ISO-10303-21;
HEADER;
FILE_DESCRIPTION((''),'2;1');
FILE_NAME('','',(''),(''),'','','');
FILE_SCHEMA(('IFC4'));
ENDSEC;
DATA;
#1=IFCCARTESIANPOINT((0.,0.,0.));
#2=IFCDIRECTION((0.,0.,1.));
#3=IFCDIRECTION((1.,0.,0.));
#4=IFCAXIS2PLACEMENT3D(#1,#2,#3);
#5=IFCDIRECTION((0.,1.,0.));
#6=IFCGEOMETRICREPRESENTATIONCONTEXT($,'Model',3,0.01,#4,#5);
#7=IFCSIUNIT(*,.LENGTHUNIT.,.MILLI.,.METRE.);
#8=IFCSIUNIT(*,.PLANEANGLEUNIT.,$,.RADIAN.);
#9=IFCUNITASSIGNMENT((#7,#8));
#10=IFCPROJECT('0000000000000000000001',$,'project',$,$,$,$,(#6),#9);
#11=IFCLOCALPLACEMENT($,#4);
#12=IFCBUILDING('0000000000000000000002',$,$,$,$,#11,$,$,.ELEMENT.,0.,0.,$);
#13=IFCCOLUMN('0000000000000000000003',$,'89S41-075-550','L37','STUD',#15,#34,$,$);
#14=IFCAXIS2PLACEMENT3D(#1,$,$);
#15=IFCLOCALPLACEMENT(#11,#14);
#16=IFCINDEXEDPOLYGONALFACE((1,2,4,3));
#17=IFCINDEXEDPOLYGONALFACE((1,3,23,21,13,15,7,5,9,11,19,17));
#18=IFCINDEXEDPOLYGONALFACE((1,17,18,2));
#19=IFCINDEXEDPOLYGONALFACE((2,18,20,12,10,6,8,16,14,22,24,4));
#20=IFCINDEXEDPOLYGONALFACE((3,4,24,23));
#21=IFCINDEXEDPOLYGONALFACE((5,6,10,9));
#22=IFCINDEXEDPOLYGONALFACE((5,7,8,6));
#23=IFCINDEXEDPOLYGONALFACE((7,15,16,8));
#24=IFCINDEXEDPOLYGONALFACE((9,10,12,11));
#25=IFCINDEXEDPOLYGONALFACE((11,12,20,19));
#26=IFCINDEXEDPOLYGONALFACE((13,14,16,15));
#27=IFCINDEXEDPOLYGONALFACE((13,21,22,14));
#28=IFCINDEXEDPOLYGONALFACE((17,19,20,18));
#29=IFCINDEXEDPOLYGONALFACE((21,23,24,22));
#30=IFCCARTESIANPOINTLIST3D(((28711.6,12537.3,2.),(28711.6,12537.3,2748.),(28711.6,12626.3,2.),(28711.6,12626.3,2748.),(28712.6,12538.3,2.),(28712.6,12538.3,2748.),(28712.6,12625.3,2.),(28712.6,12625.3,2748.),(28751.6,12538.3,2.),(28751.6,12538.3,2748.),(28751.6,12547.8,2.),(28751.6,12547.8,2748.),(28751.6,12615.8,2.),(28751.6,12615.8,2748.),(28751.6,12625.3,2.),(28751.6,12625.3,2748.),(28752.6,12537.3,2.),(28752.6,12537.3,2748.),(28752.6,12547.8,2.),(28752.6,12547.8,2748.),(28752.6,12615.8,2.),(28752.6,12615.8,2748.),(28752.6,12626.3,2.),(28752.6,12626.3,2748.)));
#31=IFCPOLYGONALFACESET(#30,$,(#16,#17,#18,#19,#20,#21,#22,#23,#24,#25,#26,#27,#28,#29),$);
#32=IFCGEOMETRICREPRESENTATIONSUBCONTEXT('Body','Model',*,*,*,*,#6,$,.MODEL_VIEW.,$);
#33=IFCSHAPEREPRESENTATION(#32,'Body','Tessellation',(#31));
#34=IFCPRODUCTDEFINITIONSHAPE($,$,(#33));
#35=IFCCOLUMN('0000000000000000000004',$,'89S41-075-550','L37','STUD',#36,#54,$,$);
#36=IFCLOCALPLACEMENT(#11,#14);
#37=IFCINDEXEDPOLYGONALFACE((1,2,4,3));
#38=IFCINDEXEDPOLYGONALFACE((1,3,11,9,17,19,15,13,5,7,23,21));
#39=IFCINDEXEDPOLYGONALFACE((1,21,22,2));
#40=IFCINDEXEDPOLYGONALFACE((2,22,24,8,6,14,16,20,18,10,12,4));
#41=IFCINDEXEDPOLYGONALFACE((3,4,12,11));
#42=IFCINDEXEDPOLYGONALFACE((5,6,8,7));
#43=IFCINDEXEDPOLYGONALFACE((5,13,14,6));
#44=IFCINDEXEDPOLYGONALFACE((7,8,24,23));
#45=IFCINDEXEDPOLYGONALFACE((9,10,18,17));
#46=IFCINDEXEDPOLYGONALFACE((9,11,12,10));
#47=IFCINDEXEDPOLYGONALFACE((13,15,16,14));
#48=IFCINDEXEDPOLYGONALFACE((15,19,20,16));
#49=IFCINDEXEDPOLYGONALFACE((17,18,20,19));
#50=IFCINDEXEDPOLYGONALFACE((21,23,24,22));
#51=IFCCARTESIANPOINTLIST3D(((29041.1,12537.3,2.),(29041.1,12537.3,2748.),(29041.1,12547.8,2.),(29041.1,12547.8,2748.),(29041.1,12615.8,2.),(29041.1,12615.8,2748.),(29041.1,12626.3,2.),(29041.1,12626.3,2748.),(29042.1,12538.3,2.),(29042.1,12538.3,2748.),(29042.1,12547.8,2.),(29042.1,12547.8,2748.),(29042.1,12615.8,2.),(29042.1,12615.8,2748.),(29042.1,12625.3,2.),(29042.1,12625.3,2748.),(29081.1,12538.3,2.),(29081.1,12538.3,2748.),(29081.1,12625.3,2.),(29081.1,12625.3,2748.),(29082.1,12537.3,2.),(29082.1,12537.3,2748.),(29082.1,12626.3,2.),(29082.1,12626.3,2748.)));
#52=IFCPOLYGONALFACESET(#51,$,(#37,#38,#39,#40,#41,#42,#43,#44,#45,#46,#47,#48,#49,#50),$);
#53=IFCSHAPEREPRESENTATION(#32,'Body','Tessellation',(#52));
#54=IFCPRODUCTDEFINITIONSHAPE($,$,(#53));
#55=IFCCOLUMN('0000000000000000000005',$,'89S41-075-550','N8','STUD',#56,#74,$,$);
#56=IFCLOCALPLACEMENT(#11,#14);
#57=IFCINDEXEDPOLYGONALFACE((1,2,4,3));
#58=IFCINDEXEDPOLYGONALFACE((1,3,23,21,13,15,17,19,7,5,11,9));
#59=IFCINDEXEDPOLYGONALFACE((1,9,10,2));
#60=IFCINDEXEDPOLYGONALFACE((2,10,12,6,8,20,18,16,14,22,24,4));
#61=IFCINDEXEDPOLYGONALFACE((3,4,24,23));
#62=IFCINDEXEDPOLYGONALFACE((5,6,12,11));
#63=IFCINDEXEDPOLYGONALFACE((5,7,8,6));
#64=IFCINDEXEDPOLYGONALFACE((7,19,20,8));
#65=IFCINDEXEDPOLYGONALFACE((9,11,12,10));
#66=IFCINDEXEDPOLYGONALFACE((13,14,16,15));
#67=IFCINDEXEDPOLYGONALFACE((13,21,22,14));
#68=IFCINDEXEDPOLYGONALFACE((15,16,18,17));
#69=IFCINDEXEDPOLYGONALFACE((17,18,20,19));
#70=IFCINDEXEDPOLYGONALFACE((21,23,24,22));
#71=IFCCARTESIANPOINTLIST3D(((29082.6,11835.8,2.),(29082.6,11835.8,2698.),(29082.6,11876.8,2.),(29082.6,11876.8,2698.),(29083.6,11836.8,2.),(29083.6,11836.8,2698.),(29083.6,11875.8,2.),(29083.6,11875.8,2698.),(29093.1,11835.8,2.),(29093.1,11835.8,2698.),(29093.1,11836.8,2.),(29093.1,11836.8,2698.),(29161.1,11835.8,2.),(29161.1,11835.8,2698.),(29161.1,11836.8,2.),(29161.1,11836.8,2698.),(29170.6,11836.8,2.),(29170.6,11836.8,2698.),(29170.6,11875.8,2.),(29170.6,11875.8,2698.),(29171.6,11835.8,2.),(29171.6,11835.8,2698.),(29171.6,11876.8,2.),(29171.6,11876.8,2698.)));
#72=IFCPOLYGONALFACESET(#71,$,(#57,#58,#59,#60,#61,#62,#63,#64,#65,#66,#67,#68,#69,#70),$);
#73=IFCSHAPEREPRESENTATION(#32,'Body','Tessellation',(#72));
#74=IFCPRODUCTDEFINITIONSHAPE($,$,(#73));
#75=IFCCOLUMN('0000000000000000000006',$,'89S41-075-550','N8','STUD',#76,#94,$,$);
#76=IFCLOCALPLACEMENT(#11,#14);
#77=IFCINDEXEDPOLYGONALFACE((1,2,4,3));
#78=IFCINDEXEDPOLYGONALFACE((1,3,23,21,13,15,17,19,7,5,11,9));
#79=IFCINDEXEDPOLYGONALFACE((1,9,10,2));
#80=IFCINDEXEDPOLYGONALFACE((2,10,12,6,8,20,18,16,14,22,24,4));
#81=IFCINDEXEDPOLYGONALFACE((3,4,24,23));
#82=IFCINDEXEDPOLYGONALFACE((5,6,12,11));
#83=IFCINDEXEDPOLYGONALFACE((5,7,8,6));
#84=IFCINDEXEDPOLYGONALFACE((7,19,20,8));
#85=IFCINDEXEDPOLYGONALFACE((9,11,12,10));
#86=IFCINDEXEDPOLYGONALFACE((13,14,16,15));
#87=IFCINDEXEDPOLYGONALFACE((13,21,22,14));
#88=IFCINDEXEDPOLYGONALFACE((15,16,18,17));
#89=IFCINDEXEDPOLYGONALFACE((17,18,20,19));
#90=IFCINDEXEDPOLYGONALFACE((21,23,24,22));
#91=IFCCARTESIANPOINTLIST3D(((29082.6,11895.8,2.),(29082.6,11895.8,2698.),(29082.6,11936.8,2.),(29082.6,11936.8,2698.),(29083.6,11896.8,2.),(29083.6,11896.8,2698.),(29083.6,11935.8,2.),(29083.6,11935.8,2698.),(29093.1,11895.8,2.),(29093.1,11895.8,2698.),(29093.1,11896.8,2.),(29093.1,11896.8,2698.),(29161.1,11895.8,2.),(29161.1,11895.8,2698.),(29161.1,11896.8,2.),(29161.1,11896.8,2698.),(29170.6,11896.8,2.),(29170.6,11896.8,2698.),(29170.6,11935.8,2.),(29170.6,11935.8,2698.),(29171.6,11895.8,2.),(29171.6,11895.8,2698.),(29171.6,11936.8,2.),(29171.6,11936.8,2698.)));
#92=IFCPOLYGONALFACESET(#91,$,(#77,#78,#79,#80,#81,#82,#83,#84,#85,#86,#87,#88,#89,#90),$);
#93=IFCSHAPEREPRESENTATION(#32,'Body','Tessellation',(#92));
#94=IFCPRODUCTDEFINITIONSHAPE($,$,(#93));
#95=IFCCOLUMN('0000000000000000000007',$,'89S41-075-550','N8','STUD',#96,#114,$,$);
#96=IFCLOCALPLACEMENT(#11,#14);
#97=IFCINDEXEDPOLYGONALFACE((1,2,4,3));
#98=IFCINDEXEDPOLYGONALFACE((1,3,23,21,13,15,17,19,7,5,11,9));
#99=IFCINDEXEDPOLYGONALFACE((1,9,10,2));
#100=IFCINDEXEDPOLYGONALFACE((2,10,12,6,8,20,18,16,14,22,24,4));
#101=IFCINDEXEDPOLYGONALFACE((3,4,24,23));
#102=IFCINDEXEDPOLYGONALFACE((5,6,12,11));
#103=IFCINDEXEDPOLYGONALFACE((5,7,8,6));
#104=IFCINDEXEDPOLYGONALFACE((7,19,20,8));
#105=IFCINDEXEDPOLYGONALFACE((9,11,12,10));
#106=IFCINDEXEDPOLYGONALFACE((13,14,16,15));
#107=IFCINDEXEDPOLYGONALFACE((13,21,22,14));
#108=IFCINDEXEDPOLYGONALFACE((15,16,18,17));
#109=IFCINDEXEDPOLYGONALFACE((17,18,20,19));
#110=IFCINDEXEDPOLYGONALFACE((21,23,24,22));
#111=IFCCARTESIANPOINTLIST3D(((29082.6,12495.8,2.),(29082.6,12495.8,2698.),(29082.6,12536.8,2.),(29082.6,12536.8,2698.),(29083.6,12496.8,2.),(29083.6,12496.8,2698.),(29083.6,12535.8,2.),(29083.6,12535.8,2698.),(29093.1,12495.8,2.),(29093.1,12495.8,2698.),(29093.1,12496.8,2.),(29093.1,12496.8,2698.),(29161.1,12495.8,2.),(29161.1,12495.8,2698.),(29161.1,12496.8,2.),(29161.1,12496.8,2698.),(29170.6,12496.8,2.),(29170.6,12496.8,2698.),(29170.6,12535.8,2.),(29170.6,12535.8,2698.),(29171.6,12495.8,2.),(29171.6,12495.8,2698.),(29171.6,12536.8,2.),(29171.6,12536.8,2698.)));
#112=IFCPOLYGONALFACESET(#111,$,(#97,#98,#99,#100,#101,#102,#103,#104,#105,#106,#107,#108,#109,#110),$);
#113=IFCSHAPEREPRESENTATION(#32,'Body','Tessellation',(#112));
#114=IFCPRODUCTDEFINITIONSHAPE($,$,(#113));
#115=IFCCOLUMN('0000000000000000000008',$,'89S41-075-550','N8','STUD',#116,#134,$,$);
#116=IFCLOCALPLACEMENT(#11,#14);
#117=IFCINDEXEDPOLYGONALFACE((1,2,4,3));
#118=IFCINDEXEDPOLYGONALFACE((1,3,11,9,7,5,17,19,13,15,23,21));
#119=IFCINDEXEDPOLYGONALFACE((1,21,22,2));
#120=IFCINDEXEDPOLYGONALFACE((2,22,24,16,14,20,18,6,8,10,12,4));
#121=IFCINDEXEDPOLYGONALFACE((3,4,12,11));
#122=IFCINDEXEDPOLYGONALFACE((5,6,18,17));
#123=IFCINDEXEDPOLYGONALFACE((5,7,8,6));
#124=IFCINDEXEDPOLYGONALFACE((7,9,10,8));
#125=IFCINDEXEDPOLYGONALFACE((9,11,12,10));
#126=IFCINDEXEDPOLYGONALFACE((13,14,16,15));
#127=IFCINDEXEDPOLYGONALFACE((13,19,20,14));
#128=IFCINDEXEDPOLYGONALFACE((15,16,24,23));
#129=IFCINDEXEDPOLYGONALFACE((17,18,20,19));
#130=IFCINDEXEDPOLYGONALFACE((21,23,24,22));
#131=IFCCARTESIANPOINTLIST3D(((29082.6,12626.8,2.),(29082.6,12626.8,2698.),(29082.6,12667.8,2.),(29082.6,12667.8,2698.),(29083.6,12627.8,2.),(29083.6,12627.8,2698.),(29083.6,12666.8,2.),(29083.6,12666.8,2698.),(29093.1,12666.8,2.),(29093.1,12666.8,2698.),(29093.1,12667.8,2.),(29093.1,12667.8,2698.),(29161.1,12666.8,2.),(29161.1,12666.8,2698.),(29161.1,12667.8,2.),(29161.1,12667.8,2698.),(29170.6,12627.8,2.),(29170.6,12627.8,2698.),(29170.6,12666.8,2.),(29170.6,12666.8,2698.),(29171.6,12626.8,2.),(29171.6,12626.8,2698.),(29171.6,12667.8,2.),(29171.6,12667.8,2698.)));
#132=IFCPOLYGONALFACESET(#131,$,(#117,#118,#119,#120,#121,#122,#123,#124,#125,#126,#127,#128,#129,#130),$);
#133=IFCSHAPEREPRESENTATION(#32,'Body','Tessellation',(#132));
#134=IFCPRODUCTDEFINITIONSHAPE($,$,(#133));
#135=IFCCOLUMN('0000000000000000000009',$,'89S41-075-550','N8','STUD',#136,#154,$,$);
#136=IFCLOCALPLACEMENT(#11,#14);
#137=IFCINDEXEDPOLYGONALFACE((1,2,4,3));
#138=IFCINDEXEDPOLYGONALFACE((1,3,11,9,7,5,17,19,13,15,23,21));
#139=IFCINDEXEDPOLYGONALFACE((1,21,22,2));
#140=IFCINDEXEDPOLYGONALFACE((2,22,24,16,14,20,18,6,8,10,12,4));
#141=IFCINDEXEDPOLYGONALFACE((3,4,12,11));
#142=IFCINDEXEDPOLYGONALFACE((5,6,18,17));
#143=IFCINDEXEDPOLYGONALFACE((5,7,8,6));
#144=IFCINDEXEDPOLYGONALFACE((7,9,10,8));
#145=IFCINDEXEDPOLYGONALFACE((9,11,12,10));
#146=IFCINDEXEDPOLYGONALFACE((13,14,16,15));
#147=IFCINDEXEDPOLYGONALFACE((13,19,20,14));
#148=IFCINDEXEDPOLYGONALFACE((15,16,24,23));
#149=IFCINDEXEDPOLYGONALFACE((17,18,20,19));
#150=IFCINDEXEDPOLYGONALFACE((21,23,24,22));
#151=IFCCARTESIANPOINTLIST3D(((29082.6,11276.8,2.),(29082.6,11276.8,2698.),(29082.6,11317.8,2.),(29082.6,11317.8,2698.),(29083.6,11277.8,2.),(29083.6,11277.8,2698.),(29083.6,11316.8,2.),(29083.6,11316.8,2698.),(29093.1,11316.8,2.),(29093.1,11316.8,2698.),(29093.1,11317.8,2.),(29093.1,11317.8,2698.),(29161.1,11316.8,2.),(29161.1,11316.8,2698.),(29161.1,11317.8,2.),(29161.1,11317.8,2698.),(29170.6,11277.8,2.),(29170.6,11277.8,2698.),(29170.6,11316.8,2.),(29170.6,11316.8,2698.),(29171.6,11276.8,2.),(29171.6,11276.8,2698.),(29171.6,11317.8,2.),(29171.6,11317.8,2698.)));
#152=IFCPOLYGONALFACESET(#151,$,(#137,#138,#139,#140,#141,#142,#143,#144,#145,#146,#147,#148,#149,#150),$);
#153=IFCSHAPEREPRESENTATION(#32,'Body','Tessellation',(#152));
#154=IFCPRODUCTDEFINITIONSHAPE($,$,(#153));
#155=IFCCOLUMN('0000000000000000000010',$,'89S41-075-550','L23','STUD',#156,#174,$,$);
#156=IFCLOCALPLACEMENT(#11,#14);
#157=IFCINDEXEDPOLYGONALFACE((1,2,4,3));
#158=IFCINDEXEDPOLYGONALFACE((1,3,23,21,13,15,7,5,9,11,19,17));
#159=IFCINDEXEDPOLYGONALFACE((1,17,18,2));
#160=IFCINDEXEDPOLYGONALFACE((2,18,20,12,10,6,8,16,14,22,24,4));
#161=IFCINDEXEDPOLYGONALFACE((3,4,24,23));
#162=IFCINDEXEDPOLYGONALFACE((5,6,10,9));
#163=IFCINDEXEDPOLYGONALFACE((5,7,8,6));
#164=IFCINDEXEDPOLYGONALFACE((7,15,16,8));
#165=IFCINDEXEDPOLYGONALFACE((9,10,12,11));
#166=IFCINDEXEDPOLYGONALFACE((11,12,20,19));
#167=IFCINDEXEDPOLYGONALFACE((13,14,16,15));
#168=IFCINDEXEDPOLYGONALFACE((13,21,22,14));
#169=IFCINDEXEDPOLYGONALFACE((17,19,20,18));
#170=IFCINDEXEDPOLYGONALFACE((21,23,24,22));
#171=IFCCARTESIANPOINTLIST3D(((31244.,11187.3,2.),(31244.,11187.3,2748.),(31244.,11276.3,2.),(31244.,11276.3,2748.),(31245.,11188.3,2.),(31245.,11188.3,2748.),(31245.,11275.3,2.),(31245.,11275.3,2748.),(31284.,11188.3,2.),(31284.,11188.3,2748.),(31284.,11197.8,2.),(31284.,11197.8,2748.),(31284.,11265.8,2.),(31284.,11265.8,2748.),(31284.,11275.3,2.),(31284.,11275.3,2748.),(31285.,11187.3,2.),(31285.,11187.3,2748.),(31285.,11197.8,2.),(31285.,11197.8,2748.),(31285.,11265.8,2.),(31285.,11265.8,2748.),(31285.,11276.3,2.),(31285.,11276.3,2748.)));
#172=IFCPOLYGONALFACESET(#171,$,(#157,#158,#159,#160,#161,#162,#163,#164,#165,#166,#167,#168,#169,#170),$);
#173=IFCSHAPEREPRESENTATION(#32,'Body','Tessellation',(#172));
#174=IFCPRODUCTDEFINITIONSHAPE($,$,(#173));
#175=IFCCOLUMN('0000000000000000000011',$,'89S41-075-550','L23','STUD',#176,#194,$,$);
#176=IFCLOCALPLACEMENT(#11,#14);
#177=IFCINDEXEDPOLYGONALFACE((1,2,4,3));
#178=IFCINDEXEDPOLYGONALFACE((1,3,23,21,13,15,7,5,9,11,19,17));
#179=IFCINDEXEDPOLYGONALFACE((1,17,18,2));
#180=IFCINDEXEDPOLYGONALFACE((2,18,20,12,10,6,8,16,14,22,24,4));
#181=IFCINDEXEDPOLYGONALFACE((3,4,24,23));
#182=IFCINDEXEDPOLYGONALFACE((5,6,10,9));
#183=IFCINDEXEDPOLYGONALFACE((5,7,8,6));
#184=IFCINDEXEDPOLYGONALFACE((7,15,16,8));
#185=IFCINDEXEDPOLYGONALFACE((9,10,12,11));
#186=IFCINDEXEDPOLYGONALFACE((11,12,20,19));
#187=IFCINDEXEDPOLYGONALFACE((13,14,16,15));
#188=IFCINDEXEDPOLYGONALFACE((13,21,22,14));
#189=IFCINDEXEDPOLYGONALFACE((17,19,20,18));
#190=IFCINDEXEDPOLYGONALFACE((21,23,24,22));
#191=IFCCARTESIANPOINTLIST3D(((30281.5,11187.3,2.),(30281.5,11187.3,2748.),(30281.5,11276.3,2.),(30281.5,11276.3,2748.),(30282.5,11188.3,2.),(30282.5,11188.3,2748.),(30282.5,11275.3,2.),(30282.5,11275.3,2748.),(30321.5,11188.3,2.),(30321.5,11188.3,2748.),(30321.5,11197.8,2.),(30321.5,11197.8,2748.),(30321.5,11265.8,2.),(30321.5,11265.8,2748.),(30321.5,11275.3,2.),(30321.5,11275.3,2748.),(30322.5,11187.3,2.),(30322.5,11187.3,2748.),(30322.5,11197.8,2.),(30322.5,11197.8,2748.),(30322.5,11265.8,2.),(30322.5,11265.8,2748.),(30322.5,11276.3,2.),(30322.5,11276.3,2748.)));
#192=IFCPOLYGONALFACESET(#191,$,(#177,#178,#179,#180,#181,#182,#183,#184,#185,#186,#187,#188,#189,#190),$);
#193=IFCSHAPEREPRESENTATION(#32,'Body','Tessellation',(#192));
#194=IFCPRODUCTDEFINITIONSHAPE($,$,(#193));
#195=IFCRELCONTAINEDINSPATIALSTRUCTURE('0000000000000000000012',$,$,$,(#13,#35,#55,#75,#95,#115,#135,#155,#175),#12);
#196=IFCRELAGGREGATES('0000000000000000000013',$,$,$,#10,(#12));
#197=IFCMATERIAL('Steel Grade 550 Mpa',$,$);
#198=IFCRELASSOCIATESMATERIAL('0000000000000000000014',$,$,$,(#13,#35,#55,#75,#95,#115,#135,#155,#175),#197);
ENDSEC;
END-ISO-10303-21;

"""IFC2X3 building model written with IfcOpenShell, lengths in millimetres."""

from ifc_helpers import new_model, si_unit, direction, frame, origin, origin_with_axes, origin_2d_with_axis, place, context, subcontext, project, spatial, c_section, extrude, source, transform, mapped, material, element, save


model = new_model("IFC2X3")

# Units and contexts
model_context = context("Model", 3, precision=0.01, world=origin_with_axes(), true_north=direction((0.0, 1.0, 0.0)))
body_context = subcontext(model_context, "Body", "Model", "MODEL_VIEW")
ifc_project = project(units=[si_unit("LENGTHUNIT", "METRE", prefix="MILLI"), si_unit("PLANEANGLEUNIT", "RADIAN")], contexts=[model_context])

# Building
building_placement = place(None, origin_with_axes())
building = spatial("IfcBuilding", under=ifc_project, at=building_placement, CompositionType="ELEMENT", ElevationOfRefHeight=0.0, ElevationOfTerrain=0.0)

# Columns
ifc_material = material(Name="Steel Grade 550 Mpa")
shared_shape_1 = source(origin(), body_context, "Body", "SweptSolid", [
    extrude(c_section(Depth=89.0, Width=41.0, WallThickness=1.0, Girth=10.5, at=origin_2d_with_axis()), origin_with_axes(), (0.0, 0.0, 1.0), 2746.0),
])
column_1_placement = place(None, frame((28732.1, 12581.8, 2.0), z_axis=(0.0, 0.0, 1.0), x_axis=(1.0, 0.0, 0.0)))
element("IfcColumn", 1, at=column_1_placement, inside=building, material=ifc_material, Name="89S41-075-550", Description="L37", ObjectType="STUD", context=body_context, shape_type="MappedRepresentation", body=[
    mapped(shared_shape_1, transform((0.0, 0.0, 0.0), scale=1.0)),
])
shared_shape_2 = source(origin(), body_context, "Body", "SweptSolid", [
    extrude(c_section(Depth=89.0, Width=41.0, WallThickness=1.0, Girth=10.5, at=origin_2d_with_axis()), origin_with_axes(), (0.0, 0.0, 1.0), 2746.0),
])
column_2_placement = place(None, frame((29061.6, 12581.8, 2.0), z_axis=(0.0, 0.0, 1.0), x_axis=(-1.0, 0.0, 0.0)))
element("IfcColumn", 2, at=column_2_placement, inside=building, material=ifc_material, Name="89S41-075-550", Description="L37", ObjectType="STUD", context=body_context, shape_type="MappedRepresentation", body=[
    mapped(shared_shape_2, transform((0.0, 0.0, 0.0), scale=1.0)),
])
shared_shape_3 = source(origin(), body_context, "Body", "SweptSolid", [
    extrude(c_section(Depth=89.0, Width=41.0, WallThickness=1.0, Girth=10.5, at=origin_2d_with_axis()), origin_with_axes(), (0.0, 0.0, 1.0), 2696.0),
])
column_3_placement = place(None, frame((29127.1, 11856.3, 2.0), z_axis=(0.0, 0.0, 1.0), x_axis=(0.0, -1.0, 0.0)))
element("IfcColumn", 3, at=column_3_placement, inside=building, material=ifc_material, Name="89S41-075-550", Description="N8", ObjectType="STUD", context=body_context, shape_type="MappedRepresentation", body=[
    mapped(shared_shape_3, transform((0.0, 0.0, 0.0), scale=1.0)),
])
shared_shape_4 = source(origin(), body_context, "Body", "SweptSolid", [
    extrude(c_section(Depth=89.0, Width=41.0, WallThickness=1.0, Girth=10.5, at=origin_2d_with_axis()), origin_with_axes(), (0.0, 0.0, 1.0), 2696.0),
])
column_4_placement = place(None, frame((29127.1, 11916.3, 2.0), z_axis=(0.0, 0.0, 1.0), x_axis=(0.0, -1.0, 0.0)))
element("IfcColumn", 4, at=column_4_placement, inside=building, material=ifc_material, Name="89S41-075-550", Description="N8", ObjectType="STUD", context=body_context, shape_type="MappedRepresentation", body=[
    mapped(shared_shape_4, transform((0.0, 0.0, 0.0), scale=1.0)),
])
shared_shape_5 = source(origin(), body_context, "Body", "SweptSolid", [
    extrude(c_section(Depth=89.0, Width=41.0, WallThickness=1.0, Girth=10.5, at=origin_2d_with_axis()), origin_with_axes(), (0.0, 0.0, 1.0), 2696.0),
])
column_5_placement = place(None, frame((29127.1, 12516.3, 2.0), z_axis=(0.0, 0.0, 1.0), x_axis=(0.0, -1.0, 0.0)))
element("IfcColumn", 5, at=column_5_placement, inside=building, material=ifc_material, Name="89S41-075-550", Description="N8", ObjectType="STUD", context=body_context, shape_type="MappedRepresentation", body=[
    mapped(shared_shape_5, transform((0.0, 0.0, 0.0), scale=1.0)),
])
shared_shape_6 = source(origin(), body_context, "Body", "SweptSolid", [
    extrude(c_section(Depth=89.0, Width=41.0, WallThickness=1.0, Girth=10.5, at=origin_2d_with_axis()), origin_with_axes(), (0.0, 0.0, 1.0), 2696.0),
])
column_6_placement = place(None, frame((29127.1, 12647.3, 2.0), z_axis=(0.0, 0.0, 1.0), x_axis=(0.0, 1.0, 0.0)))
element("IfcColumn", 6, at=column_6_placement, inside=building, material=ifc_material, Name="89S41-075-550", Description="N8", ObjectType="STUD", context=body_context, shape_type="MappedRepresentation", body=[
    mapped(shared_shape_6, transform((0.0, 0.0, 0.0), scale=1.0)),
])
shared_shape_7 = source(origin(), body_context, "Body", "SweptSolid", [
    extrude(c_section(Depth=89.0, Width=41.0, WallThickness=1.0, Girth=10.5, at=origin_2d_with_axis()), origin_with_axes(), (0.0, 0.0, 1.0), 2696.0),
])
column_7_placement = place(None, frame((29127.1, 11297.3, 2.0), z_axis=(0.0, 0.0, 1.0), x_axis=(0.0, 1.0, 0.0)))
element("IfcColumn", 7, at=column_7_placement, inside=building, material=ifc_material, Name="89S41-075-550", Description="N8", ObjectType="STUD", context=body_context, shape_type="MappedRepresentation", body=[
    mapped(shared_shape_7, transform((0.0, 0.0, 0.0), scale=1.0)),
])
shared_shape_8 = source(origin(), body_context, "Body", "SweptSolid", [
    extrude(c_section(Depth=89.0, Width=41.0, WallThickness=1.0, Girth=10.5, at=origin_2d_with_axis()), origin_with_axes(), (0.0, 0.0, 1.0), 2746.0),
])
column_8_placement = place(None, frame((31264.5, 11231.8, 2.0), z_axis=(0.0, 0.0, 1.0), x_axis=(1.0, 0.0, 0.0)))
element("IfcColumn", 8, at=column_8_placement, inside=building, material=ifc_material, Name="89S41-075-550", Description="L23", ObjectType="STUD", context=body_context, shape_type="MappedRepresentation", body=[
    mapped(shared_shape_8, transform((0.0, 0.0, 0.0), scale=1.0)),
])
shared_shape_9 = source(origin(), body_context, "Body", "SweptSolid", [
    extrude(c_section(Depth=89.0, Width=41.0, WallThickness=1.0, Girth=10.5, at=origin_2d_with_axis()), origin_with_axes(), (0.0, 0.0, 1.0), 2746.0),
])
column_9_placement = place(None, frame((30302.0, 11231.8, 2.0), z_axis=(0.0, 0.0, 1.0), x_axis=(1.0, 0.0, 0.0)))
element("IfcColumn", 9, at=column_9_placement, inside=building, material=ifc_material, Name="89S41-075-550", Description="L23", ObjectType="STUD", context=body_context, shape_type="MappedRepresentation", body=[
    mapped(shared_shape_9, transform((0.0, 0.0, 0.0), scale=1.0)),
])

save(model, "model.ifc")
